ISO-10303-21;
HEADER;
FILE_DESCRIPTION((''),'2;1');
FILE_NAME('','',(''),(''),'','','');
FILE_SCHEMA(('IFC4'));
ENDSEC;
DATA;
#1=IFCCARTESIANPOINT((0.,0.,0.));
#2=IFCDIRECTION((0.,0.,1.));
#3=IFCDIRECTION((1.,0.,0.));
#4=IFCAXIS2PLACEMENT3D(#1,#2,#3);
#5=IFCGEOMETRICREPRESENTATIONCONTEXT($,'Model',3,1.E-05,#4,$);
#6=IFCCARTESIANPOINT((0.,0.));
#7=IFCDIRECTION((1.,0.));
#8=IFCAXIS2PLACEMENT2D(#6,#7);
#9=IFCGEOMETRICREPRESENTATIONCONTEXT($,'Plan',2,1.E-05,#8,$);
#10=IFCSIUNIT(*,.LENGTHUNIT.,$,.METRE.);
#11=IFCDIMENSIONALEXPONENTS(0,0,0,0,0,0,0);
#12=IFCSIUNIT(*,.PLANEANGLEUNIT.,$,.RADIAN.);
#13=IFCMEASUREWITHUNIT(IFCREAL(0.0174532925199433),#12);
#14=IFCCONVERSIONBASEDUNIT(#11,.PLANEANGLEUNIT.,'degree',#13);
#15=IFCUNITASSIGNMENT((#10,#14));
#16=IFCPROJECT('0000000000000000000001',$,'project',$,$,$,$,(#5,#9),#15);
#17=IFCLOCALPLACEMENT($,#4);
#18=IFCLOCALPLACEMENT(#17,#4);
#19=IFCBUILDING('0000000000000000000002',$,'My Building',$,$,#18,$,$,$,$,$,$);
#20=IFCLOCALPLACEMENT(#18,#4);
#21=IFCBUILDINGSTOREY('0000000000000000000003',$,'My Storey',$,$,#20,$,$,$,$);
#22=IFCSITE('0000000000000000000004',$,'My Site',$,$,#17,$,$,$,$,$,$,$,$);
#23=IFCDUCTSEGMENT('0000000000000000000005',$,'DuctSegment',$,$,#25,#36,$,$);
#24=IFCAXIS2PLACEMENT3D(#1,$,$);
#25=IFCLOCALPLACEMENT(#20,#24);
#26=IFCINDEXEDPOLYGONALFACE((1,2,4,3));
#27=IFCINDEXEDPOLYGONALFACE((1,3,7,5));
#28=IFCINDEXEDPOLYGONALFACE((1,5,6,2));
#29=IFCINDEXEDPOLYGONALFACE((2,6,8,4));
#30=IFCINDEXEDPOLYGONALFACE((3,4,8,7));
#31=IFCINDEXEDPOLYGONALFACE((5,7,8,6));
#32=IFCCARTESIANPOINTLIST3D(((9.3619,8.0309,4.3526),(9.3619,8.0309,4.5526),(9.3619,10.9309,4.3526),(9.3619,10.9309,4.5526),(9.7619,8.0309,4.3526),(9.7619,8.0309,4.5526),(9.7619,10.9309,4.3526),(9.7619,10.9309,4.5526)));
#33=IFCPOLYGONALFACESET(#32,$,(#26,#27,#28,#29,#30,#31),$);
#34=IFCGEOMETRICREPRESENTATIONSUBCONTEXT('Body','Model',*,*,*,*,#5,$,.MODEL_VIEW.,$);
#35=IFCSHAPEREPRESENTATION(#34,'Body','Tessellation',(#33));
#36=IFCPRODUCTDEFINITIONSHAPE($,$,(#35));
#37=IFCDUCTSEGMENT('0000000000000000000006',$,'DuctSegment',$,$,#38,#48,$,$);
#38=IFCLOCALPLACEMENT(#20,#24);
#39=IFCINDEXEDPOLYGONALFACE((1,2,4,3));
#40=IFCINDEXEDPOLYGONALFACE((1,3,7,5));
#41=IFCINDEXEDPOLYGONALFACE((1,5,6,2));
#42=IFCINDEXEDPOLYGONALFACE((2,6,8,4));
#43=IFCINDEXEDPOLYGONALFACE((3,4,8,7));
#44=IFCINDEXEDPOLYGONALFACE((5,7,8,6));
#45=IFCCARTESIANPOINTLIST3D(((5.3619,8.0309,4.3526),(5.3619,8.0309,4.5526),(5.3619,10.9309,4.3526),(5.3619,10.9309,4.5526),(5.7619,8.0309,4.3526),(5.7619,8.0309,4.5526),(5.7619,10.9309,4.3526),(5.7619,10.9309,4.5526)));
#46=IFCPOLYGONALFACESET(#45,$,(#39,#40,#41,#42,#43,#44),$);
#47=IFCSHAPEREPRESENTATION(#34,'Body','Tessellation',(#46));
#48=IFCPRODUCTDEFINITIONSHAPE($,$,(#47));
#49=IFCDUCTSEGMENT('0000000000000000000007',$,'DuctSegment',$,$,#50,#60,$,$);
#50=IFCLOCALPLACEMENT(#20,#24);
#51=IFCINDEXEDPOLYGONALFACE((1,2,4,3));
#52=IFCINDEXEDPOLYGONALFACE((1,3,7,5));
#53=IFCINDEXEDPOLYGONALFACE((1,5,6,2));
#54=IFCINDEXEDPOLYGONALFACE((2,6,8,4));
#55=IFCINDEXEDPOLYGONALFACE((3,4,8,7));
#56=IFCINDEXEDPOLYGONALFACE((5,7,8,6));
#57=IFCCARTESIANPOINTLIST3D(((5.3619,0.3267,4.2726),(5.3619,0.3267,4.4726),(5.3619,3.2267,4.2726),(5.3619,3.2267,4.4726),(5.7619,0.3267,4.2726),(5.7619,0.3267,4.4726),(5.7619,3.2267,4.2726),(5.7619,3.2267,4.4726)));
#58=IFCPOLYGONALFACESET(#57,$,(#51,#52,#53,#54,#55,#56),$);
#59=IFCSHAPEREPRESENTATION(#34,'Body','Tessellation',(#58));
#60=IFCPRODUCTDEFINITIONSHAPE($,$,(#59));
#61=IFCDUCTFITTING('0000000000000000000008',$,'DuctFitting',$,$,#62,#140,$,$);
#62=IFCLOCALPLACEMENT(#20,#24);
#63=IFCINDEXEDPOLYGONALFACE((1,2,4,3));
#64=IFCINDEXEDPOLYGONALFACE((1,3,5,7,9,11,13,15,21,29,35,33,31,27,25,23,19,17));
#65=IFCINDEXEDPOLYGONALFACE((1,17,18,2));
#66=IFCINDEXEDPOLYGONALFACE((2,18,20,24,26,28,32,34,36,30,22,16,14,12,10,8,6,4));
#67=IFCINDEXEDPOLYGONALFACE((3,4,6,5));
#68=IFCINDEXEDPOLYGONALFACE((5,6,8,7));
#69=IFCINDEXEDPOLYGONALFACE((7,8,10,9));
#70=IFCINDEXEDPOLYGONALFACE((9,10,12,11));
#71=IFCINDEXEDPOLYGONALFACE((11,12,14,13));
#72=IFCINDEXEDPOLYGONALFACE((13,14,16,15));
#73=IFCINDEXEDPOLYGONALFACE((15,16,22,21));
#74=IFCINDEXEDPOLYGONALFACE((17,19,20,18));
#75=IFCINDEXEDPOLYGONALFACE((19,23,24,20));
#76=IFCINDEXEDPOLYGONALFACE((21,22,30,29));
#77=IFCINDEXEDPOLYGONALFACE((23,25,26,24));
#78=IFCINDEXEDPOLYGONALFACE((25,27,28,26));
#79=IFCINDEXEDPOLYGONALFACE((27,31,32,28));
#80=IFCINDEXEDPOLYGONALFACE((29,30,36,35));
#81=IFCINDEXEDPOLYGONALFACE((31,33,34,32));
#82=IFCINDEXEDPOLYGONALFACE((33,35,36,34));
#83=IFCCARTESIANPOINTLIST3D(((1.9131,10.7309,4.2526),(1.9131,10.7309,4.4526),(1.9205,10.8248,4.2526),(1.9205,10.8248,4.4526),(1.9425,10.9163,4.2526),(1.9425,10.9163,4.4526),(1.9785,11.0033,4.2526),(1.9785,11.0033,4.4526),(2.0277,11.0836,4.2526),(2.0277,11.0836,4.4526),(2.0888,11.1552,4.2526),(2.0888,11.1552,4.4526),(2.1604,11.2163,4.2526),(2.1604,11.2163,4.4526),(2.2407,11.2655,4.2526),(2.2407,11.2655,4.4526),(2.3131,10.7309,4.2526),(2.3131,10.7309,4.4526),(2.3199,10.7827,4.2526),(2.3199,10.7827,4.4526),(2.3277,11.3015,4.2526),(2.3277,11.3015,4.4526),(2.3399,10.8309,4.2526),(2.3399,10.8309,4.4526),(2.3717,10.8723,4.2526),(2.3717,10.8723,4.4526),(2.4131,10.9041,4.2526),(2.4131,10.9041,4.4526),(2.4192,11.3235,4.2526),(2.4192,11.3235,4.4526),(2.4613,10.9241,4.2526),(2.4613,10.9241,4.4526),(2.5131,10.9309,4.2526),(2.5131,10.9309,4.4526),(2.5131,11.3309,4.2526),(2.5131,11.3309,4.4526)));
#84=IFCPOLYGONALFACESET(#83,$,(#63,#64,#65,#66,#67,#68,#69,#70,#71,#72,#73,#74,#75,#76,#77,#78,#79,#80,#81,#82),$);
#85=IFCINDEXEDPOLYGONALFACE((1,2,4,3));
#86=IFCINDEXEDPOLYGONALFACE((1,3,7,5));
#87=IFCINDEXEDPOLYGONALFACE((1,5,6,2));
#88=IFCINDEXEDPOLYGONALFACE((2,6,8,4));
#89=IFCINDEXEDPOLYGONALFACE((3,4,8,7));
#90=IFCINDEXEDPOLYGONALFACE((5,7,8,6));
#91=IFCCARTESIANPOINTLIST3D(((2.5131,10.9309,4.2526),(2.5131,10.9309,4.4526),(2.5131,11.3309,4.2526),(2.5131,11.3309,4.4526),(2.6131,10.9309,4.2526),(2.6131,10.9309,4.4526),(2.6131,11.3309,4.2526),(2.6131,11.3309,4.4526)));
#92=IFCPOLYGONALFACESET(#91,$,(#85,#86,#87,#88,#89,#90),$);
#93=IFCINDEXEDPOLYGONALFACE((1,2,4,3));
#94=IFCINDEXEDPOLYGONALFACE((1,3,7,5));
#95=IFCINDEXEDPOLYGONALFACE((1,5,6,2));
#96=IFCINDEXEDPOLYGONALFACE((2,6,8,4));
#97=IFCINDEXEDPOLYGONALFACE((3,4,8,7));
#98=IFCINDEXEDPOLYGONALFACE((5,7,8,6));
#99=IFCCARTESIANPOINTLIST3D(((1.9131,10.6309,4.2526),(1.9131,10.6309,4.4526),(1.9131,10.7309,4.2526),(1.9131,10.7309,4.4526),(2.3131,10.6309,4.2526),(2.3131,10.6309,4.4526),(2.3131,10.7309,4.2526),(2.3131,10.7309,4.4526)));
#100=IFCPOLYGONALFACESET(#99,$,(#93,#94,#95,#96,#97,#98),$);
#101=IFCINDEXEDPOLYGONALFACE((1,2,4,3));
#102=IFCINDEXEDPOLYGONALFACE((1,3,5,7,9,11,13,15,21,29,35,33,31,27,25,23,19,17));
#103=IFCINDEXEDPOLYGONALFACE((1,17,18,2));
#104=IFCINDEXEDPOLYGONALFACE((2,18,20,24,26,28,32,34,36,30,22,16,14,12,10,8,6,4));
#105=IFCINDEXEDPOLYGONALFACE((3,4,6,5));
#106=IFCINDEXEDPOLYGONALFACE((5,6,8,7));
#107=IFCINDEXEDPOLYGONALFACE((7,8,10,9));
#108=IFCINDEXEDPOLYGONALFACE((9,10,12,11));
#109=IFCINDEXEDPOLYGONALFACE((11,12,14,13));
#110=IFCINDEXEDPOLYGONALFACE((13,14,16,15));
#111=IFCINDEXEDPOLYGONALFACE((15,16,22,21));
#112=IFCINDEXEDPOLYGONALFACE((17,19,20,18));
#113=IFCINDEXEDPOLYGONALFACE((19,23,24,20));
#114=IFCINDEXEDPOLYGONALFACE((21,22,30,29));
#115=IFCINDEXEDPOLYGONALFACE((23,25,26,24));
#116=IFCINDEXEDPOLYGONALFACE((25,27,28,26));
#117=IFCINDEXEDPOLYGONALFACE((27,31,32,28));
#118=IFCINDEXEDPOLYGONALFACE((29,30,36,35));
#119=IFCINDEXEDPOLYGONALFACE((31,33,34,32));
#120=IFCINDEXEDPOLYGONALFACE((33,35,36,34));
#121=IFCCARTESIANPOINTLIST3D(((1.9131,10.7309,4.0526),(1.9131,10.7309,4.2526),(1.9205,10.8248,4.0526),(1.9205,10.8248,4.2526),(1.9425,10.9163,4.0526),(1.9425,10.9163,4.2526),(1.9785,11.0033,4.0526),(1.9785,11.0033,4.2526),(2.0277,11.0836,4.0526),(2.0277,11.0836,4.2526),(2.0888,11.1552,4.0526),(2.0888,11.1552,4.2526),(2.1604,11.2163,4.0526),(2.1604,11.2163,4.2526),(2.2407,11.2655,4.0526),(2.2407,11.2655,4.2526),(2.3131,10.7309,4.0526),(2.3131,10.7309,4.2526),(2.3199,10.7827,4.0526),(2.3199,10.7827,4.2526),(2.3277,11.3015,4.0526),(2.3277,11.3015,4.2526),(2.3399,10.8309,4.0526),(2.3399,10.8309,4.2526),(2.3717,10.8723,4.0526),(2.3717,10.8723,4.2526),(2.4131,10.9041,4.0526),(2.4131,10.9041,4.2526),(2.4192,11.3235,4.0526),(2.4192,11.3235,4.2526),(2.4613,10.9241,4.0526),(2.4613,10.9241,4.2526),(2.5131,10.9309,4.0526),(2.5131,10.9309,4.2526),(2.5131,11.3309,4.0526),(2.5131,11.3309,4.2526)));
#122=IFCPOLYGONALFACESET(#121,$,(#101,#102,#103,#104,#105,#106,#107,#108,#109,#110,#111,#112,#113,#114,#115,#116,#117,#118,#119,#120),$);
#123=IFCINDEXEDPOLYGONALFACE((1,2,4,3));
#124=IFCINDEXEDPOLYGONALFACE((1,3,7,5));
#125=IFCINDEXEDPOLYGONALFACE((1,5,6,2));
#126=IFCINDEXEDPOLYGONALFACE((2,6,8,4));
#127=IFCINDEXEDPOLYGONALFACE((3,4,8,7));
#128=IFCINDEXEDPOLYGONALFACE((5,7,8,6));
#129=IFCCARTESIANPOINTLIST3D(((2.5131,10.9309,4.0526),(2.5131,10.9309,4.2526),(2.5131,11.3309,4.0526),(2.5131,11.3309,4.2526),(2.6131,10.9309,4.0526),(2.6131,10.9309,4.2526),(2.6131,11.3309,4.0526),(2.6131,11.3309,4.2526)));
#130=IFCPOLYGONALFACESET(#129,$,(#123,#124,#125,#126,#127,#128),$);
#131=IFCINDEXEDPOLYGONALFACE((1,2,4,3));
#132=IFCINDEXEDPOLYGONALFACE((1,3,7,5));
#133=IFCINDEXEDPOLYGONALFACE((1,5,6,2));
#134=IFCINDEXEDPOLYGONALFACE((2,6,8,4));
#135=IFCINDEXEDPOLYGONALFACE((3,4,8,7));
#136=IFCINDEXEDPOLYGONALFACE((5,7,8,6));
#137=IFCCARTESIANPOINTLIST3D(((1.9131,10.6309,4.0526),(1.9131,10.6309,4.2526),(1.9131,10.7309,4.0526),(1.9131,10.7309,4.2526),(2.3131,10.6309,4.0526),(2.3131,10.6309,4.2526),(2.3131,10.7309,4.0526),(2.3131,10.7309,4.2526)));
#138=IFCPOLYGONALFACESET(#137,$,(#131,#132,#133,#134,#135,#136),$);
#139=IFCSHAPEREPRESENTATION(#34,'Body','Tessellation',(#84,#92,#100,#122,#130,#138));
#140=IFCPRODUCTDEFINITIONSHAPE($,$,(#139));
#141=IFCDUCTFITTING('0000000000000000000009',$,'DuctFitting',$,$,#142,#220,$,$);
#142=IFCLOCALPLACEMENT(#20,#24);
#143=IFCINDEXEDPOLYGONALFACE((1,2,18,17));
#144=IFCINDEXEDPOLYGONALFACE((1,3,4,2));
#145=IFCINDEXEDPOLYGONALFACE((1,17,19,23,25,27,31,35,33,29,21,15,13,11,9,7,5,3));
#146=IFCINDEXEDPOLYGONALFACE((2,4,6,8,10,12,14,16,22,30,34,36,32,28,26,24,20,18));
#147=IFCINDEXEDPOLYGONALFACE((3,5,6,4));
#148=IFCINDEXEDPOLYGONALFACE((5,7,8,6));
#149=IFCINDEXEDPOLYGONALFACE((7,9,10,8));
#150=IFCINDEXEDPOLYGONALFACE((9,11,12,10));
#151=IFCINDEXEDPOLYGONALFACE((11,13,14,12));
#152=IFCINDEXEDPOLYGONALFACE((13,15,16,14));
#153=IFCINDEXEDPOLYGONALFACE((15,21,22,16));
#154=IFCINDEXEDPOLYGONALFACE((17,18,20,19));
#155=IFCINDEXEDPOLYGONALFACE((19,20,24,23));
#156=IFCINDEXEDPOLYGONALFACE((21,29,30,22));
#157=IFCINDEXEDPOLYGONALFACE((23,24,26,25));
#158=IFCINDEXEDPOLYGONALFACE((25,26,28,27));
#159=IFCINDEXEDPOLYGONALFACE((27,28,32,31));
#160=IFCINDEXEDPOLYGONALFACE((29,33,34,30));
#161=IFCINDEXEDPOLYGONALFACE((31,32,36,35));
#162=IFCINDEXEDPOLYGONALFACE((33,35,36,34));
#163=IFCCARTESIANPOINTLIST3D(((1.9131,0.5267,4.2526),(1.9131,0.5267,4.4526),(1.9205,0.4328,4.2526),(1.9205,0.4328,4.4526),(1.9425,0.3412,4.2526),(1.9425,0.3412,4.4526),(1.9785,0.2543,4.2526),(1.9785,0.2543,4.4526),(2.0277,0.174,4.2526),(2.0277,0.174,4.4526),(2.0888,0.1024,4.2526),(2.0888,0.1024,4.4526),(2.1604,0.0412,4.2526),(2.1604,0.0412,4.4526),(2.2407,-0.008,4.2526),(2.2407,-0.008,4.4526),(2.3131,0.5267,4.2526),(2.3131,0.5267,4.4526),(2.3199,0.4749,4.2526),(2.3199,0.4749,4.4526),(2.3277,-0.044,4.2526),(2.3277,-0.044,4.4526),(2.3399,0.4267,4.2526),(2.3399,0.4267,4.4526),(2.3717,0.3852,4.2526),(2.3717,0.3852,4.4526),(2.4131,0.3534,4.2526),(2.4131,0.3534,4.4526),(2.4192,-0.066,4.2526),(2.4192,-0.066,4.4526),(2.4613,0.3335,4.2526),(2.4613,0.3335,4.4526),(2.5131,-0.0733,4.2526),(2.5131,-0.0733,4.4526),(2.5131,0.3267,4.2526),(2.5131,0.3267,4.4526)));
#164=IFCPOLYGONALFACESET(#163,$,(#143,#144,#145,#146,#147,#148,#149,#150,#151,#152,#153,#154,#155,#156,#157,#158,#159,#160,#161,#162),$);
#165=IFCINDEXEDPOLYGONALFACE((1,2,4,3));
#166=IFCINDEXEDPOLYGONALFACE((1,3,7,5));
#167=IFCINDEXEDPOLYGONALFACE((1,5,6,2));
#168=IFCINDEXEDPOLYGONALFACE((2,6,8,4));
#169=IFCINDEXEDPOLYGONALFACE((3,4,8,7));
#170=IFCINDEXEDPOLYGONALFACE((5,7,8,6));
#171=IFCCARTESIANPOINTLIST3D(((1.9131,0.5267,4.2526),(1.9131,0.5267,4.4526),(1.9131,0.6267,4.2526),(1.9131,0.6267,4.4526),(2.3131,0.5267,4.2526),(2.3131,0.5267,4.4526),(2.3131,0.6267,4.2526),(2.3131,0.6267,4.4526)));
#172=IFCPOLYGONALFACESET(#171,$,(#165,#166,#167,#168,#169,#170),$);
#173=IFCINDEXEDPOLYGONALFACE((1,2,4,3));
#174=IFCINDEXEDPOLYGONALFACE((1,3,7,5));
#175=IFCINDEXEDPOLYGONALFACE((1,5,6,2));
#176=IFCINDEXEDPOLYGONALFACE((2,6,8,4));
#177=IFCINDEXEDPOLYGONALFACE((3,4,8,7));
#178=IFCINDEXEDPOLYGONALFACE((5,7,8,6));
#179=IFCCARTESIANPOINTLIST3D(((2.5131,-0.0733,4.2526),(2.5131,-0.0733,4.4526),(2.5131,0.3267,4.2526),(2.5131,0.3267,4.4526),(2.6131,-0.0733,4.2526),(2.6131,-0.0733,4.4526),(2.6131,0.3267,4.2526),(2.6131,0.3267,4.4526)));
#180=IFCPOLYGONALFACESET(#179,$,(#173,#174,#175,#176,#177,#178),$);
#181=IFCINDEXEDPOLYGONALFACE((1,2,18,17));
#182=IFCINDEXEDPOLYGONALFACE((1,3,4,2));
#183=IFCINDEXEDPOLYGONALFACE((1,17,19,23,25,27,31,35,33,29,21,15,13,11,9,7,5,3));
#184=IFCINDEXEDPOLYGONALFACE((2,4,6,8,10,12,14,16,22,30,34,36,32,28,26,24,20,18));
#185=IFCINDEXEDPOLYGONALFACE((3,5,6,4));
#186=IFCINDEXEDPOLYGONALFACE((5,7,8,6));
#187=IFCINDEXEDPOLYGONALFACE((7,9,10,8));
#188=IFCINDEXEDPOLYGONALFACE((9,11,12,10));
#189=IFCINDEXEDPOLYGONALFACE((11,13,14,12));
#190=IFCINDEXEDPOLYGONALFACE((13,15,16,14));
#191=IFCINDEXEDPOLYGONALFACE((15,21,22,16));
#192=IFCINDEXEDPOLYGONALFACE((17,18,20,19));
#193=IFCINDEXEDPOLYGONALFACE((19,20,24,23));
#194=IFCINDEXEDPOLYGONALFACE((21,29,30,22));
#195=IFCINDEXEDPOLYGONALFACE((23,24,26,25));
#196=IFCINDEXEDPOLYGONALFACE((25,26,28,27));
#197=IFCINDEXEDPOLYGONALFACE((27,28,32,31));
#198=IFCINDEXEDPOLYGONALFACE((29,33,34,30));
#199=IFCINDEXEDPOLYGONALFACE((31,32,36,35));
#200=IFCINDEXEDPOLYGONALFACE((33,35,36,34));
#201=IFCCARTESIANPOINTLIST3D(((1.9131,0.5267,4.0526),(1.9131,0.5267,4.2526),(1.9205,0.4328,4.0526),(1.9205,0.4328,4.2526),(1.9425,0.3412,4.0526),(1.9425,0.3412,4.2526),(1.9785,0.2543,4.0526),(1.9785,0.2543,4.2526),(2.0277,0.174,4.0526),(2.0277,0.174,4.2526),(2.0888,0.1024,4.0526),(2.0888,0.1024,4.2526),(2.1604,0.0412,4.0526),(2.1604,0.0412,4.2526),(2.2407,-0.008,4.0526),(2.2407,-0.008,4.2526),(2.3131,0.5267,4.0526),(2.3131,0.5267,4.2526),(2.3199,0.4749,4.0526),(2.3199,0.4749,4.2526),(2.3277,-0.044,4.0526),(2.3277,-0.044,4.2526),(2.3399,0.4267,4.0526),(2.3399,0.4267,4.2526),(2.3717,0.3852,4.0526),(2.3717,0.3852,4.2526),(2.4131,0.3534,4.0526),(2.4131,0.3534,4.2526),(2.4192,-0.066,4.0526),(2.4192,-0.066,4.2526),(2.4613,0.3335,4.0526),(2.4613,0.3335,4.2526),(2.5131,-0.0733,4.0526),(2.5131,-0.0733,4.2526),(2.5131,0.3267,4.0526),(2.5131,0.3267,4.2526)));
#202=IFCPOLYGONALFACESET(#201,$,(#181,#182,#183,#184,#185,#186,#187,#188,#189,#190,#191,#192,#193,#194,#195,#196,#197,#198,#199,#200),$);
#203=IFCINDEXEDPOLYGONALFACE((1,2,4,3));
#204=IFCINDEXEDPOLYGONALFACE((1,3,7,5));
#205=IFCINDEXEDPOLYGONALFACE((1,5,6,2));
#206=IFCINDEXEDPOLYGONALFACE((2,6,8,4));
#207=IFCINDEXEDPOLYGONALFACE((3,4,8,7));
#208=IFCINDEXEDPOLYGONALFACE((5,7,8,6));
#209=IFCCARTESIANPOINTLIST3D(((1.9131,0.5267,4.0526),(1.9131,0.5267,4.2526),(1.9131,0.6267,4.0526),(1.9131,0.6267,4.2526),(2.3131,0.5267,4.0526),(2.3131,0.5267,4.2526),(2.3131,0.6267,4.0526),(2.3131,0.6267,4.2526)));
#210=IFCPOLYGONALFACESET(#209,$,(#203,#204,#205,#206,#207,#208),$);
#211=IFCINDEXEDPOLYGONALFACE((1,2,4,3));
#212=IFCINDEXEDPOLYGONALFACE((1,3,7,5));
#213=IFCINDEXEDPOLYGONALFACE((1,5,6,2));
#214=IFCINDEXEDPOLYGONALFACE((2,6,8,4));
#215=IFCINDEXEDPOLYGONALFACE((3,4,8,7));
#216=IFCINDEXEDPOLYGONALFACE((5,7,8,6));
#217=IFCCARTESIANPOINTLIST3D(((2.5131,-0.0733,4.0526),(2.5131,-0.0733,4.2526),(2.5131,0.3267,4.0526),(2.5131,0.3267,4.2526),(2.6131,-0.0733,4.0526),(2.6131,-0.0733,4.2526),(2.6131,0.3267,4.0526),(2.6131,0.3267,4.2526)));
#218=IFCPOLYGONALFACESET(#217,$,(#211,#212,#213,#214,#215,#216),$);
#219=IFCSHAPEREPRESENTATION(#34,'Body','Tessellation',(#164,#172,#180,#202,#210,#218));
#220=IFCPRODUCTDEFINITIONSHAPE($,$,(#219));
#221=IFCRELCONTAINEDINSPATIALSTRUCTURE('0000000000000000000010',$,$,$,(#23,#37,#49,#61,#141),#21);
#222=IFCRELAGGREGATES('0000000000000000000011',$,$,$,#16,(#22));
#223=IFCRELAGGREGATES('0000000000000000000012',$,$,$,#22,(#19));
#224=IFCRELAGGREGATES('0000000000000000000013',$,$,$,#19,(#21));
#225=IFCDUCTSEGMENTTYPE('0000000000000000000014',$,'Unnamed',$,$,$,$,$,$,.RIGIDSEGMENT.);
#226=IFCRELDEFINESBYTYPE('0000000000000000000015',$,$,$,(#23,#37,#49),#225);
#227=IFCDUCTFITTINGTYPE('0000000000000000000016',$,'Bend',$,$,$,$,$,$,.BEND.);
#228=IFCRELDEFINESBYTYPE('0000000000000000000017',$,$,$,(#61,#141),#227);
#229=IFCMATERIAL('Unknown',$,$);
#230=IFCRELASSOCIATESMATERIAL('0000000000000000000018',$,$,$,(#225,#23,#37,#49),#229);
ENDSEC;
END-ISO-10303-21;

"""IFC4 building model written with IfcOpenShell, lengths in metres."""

from ifc_helpers import new_model, entity, si_unit, converted_unit, frame, origin_with_axes, origin_2d_with_axis, place, context, subcontext, project, spatial, line, arc, indexed_curve, rectangle, outline, extrude, source, transform, mapped, material, material_profile, profile_set, profile_usage, type_object, type_shapes, element, save


model = new_model("IFC4")

# Units and contexts
model_context = context("Model", 3, precision=1e-05, world=origin_with_axes())
plan_context = context("Plan", 2, precision=1e-05, world=origin_2d_with_axis())
body_context = subcontext(model_context, "Body", "Model", "MODEL_VIEW")
ifc_project = project(units=[si_unit("LENGTHUNIT", "METRE"), converted_unit("PLANEANGLEUNIT", "degree", entity("IfcReal", 0.0174532925199433), si_unit("PLANEANGLEUNIT", "RADIAN"), dimensions=[0, 0, 0, 0, 0, 0, 0])], contexts=[model_context, plan_context])

# Site, building, storey
site_placement = place(None, origin_with_axes())
site = spatial("IfcSite", under=ifc_project, at=site_placement, Name="My Site")
building_placement = place(site_placement, origin_with_axes())
building = spatial("IfcBuilding", under=site, at=building_placement, Name="My Building")
storey_placement = place(building_placement, origin_with_axes())
storey = spatial("IfcBuildingStorey", under=building, at=storey_placement, Name="My Storey")

# Shared definitions
ifc_material = material(Name="Unknown")

# Duct segments
ifc_material_profile_1 = material_profile(ifc_material, rectangle(XDim=0.4, YDim=0.2))
ifc_profile_set_1 = profile_set([ifc_material_profile_1])
duct_segment_type = type_object("IfcDuctSegmentType", Name="Unnamed", PredefinedType="RIGIDSEGMENT", material=ifc_profile_set_1)
ifc_profile_usage_1 = profile_usage(ifc_profile_set_1, cardinal=5)
duct_segment_1_placement = place(storey_placement, frame((9.5619, 10.9309, 4.4526), z_axis=(0.0, -1.0, 0.0), x_axis=(1.0, 0.0, 0.0)))
element("IfcDuctSegment", 1, at=duct_segment_1_placement, inside=storey, type_object=duct_segment_type, material=ifc_profile_usage_1, Name="DuctSegment", context=body_context, shape_type="SweptSolid", body=[
    extrude(rectangle(XDim=0.4, YDim=0.2), origin_with_axes(), (0.0, 0.0, 1.0), 2.9),
])
ifc_profile_usage_2 = profile_usage(ifc_profile_set_1, cardinal=5)
duct_segment_2_placement = place(storey_placement, frame((5.5619, 10.9309, 4.4526), z_axis=(0.0, -1.0, 0.0), x_axis=(1.0, 0.0, 0.0)))
element("IfcDuctSegment", 2, at=duct_segment_2_placement, inside=storey, type_object=duct_segment_type, material=ifc_profile_usage_2, Name="DuctSegment", context=body_context, shape_type="SweptSolid", body=[
    extrude(rectangle(XDim=0.4, YDim=0.2), origin_with_axes(), (0.0, 0.0, 1.0), 2.9),
])
ifc_profile_usage_3 = profile_usage(ifc_profile_set_1, cardinal=5)
duct_segment_3_placement = place(storey_placement, frame((5.5619, 0.3267, 4.3726), z_axis=(0.0, 1.0, 0.0), x_axis=(-1.0, 0.0, 0.0)))
element("IfcDuctSegment", 3, at=duct_segment_3_placement, inside=storey, type_object=duct_segment_type, material=ifc_profile_usage_3, Name="DuctSegment", context=body_context, shape_type="SweptSolid", body=[
    extrude(rectangle(XDim=0.4, YDim=0.2), origin_with_axes(), (0.0, 0.0, 1.0), 2.9),
])

# Duct fittings
duct_fitting_type_1 = type_object("IfcDuctFittingType", Name="Bend", PredefinedType="BEND")
shared_shape_1 = source(origin_with_axes(), body_context, "Body", "SweptSolid", [
    extrude(outline(indexed_curve([(0.2, 0.0), (0.2586, 0.1414), (0.4, 0.2), (0.4, 0.6), (-0.0243, 0.4243), (-0.2, 0.0)], segments=[arc(1, 2, 3), line(3, 4), arc(4, 5, 6), line(6, 1)])), frame((0.0, -0.1, 0.1), z_axis=(0.0, -1.0, 0.0), x_axis=(1.0, 0.0, 0.0)), (0.0, 0.0, -1.0), 0.2),
    extrude(rectangle(XDim=0.4, YDim=0.2), origin_with_axes(), (0.0, 0.0, 1.0), 0.1),
    extrude(rectangle(XDim=0.4, YDim=0.2), frame((0.4, 0.0, 0.5), z_axis=(1.0, 0.0, 0.0), x_axis=(0.0, 0.0, 1.0)), (0.0, 0.0, 1.0), 0.1),
    extrude(outline(indexed_curve([(0.2, 0.0), (0.2586, 0.1414), (0.4, 0.2), (0.4, 0.6), (-0.0243, 0.4243), (-0.2, 0.0)], segments=[arc(1, 2, 3), line(3, 4), arc(4, 5, 6), line(6, 1)])), frame((0.0, -0.3, 0.1), z_axis=(0.0, -1.0, 0.0), x_axis=(1.0, 0.0, 0.0)), (0.0, 0.0, -1.0), 0.2),
    extrude(rectangle(XDim=0.4, YDim=0.2), frame((0.0, -0.2, 0.0), z_axis=(0.0, 0.0, 1.0), x_axis=(1.0, 0.0, 0.0)), (0.0, 0.0, 1.0), 0.1),
    extrude(rectangle(XDim=0.4, YDim=0.2), frame((0.4, -0.2, 0.5), z_axis=(1.0, 0.0, 0.0), x_axis=(0.0, 0.0, 1.0)), (0.0, 0.0, 1.0), 0.1),
])
type_shapes(duct_fitting_type_1, [shared_shape_1])
for number, where, z_axis, x_axis, name in (
    (4, (2.6131, 11.1309, 4.3526), (-1.0, 0.0, 0.0), (0.0, -1.0, 0.0), "DuctFitting"),
    (5, (2.1131, 0.6267, 4.3526), (0.0, -1.0, 0.0), (1.0, 0.0, 0.0), "DuctFitting"),
):
    element("IfcDuctFitting", number, at=place(storey_placement, frame(where, z_axis=z_axis, x_axis=x_axis)), inside=storey, type_object=duct_fitting_type_1, Name=name, context=body_context, shape_type="MappedRepresentation", body=[
        mapped(shared_shape_1, transform((0.0, 0.0, 0.0), x_axis=(1.0, 0.0, 0.0), y_axis=(0.0, 1.0, 0.0), z_axis=(0.0, 0.0, 1.0), scale=1.0)),
    ])

save(model, "model.ifc")
